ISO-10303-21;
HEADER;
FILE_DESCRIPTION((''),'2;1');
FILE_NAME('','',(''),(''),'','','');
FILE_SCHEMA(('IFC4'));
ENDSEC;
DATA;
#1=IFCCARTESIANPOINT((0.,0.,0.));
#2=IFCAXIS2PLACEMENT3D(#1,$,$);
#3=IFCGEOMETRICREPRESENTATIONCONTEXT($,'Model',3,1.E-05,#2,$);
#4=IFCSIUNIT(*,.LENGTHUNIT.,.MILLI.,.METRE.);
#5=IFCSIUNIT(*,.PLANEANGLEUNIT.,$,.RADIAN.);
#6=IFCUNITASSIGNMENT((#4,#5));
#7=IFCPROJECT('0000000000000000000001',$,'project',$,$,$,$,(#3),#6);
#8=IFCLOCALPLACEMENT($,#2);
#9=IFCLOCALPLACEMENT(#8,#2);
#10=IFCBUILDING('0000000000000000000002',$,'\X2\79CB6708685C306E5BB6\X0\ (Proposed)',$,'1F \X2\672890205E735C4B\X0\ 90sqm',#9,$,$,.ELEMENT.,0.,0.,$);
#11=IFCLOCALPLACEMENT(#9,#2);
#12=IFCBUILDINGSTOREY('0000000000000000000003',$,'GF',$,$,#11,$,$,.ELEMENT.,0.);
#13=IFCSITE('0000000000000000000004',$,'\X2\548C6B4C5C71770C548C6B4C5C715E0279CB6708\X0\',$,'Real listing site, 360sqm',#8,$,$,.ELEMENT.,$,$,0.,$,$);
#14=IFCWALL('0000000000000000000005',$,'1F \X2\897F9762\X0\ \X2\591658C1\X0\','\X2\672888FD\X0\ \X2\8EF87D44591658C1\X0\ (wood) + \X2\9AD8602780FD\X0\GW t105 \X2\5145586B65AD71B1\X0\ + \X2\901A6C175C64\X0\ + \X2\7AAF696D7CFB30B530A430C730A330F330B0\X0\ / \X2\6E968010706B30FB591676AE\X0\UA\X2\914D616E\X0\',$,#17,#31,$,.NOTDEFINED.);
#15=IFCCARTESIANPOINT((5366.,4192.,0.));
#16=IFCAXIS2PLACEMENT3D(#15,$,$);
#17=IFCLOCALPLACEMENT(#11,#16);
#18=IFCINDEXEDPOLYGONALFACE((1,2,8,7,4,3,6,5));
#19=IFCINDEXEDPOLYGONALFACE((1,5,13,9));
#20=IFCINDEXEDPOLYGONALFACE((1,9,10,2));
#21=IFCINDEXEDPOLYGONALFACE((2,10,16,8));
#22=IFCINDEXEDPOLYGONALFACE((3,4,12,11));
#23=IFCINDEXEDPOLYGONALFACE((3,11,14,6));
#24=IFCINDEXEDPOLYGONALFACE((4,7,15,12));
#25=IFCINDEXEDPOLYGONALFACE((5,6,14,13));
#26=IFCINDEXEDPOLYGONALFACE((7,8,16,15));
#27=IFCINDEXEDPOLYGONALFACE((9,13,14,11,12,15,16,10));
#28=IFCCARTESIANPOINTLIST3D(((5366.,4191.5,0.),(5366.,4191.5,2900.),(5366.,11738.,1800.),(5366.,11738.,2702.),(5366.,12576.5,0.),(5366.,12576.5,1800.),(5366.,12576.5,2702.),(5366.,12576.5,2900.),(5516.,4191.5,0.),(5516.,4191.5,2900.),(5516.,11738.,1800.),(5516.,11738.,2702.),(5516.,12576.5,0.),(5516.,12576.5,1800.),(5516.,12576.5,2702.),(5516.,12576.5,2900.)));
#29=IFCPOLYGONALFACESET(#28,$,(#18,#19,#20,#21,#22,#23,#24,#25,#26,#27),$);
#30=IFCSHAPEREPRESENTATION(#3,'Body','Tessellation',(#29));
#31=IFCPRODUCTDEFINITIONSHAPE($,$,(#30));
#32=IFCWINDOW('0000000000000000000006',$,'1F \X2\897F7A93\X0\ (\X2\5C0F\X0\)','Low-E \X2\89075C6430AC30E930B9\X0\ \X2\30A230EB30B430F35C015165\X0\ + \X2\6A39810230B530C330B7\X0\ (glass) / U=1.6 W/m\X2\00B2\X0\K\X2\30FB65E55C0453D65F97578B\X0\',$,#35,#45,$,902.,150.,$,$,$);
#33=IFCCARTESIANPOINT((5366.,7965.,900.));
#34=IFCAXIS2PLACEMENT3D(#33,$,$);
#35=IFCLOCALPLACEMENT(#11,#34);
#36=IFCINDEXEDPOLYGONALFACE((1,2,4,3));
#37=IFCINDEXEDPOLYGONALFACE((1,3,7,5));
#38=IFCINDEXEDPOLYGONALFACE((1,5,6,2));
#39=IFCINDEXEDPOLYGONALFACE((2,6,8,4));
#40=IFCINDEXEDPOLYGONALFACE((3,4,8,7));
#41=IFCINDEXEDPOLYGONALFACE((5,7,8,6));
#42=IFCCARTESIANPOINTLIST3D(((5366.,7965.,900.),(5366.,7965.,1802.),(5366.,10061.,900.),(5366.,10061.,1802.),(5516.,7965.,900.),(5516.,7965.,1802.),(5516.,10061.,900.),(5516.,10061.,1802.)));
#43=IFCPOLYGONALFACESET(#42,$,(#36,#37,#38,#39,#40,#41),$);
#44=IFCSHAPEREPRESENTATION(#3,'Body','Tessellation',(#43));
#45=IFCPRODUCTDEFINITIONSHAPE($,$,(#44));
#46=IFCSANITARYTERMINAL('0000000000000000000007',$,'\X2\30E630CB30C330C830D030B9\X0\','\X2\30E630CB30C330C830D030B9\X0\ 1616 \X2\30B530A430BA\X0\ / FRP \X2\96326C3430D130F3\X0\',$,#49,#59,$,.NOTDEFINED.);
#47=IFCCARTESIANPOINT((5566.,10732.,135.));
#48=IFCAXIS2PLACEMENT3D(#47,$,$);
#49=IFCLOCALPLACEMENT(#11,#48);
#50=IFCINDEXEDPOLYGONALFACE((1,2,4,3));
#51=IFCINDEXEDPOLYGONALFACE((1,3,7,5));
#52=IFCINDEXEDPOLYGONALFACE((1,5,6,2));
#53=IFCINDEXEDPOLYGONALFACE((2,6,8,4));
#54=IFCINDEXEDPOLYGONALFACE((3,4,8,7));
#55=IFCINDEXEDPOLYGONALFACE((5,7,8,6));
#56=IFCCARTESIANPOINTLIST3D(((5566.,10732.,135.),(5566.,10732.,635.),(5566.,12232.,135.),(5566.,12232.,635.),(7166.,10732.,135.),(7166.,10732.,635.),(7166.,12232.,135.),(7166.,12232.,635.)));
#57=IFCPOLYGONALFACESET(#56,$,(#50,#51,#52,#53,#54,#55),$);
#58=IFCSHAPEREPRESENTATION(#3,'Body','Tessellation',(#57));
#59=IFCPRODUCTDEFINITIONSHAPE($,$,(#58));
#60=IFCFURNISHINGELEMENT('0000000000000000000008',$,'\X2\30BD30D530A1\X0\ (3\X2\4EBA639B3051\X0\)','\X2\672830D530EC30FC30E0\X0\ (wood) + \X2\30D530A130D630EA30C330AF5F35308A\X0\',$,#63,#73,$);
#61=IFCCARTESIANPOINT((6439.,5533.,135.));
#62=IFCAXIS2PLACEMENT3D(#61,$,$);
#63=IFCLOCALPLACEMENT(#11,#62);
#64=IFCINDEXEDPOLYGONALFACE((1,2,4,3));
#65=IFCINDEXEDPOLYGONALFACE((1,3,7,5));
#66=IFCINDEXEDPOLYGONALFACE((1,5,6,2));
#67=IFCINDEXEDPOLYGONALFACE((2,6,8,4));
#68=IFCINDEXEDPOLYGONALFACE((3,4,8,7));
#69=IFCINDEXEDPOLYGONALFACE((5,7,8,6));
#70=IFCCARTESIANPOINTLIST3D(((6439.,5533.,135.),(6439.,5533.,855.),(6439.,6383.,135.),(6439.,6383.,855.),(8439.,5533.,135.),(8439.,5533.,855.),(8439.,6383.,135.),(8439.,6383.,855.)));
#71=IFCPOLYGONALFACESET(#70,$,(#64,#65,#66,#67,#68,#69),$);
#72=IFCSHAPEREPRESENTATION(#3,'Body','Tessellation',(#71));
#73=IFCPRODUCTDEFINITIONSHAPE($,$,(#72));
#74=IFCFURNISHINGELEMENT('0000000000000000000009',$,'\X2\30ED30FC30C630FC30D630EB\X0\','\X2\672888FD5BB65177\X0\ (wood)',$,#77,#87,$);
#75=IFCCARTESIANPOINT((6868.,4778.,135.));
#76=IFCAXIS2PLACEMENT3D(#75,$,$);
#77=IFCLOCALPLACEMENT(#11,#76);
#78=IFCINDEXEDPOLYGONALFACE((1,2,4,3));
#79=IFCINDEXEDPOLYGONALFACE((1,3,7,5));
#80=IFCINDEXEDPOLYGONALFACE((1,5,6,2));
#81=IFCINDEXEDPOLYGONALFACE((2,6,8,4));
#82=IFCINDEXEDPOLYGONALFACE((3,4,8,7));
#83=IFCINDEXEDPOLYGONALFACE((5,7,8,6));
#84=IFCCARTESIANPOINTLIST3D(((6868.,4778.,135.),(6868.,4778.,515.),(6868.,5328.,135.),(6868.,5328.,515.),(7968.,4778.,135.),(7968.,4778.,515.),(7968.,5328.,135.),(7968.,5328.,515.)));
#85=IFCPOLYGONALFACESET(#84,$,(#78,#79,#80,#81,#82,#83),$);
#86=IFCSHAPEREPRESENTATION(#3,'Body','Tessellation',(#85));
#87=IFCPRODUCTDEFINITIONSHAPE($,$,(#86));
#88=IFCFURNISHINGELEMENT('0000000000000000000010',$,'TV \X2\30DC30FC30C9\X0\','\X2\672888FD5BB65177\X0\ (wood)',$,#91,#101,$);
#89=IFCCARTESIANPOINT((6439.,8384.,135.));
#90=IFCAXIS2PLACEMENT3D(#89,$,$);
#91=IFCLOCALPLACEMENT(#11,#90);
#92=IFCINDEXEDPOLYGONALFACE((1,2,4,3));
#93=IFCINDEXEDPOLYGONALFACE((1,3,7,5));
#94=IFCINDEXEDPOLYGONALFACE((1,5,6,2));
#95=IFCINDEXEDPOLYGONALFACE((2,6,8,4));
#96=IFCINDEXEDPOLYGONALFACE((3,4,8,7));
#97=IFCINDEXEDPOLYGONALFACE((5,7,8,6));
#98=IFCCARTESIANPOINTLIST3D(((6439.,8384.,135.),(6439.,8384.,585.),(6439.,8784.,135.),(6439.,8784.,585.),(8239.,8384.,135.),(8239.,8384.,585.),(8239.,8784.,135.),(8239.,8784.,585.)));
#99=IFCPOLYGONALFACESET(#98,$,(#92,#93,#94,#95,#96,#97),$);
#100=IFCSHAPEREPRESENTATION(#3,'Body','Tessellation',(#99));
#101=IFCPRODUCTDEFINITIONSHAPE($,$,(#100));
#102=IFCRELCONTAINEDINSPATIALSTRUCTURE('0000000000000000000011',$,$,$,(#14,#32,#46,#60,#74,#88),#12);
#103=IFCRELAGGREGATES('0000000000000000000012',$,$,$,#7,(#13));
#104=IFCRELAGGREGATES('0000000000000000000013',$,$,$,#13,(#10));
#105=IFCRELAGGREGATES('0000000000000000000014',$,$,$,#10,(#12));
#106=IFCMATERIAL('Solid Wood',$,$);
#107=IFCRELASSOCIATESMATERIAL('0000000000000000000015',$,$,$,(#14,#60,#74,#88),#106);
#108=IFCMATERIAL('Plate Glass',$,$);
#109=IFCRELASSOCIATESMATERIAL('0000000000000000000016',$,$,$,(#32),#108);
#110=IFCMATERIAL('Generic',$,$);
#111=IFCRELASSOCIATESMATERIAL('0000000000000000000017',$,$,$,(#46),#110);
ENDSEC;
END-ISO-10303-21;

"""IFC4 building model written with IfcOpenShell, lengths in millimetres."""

from ifc_helpers import new_model, si_unit, frame, frame_2d, origin, place, context, project, spatial, rectangle, extrude, material, element, fill, save


model = new_model("IFC4")

# Units and contexts
model_context = context("Model", 3, precision=1e-05, world=origin())
ifc_project = project(units=[si_unit("LENGTHUNIT", "METRE", prefix="MILLI"), si_unit("PLANEANGLEUNIT", "RADIAN")], contexts=[model_context])

# Site, building, storey
site_placement = place(None, origin())
site = spatial("IfcSite", under=ifc_project, at=site_placement, Name="和歌山県和歌山市秋月", ObjectType="Real listing site, 360sqm", CompositionType="ELEMENT", RefElevation=0.0)
building_placement = place(site_placement, origin())
building = spatial("IfcBuilding", under=site, at=building_placement, Name="秋月桜の家 (Proposed)", ObjectType="1F 木造平屋 90sqm", CompositionType="ELEMENT", ElevationOfRefHeight=0.0, ElevationOfTerrain=0.0)
storey_placement = place(building_placement, origin())
storey = spatial("IfcBuildingStorey", under=building, at=storey_placement, Name="GF", CompositionType="ELEMENT", Elevation=0.0)

# Shared definitions
ifc_material_1 = material(Name="Solid Wood")

# Shared definitions
ifc_material_2 = material(Name="Plate Glass")

# Wall, opening, window
wall_1_placement = place(storey_placement, frame((5366.0, 4192.0, 0.0)))
wall_1 = element("IfcWall", 1, at=wall_1_placement, inside=storey, material=ifc_material_1, Name="1F 西面 外壁", Description="木製 軸組外壁 (wood) + 高性能GW t105 充填断熱 + 通気層 + 窯業系サイディング / 準耐火・外皮UA配慮", PredefinedType="NOTDEFINED", context=model_context, shape_type="SweptSolid", body=[
    extrude(rectangle(XDim=150.0, YDim=8385.0, at=frame_2d((75.0, 4192.0))), frame((5366.0, 4192.0, 0.0)), (0.0, 0.0, 1.0), 2900.0),
])
opening_1_placement = place(storey_placement, frame((5366.0, 7965.0, 900.0)))
opening_1 = element("IfcOpeningElement", 2, at=opening_1_placement, cuts=wall_1, PredefinedType="NOTDEFINED", context=model_context, shape_type="SweptSolid", body=[
    extrude(rectangle(XDim=150.0, YDim=2096.0, at=frame_2d((75.0, 1048.0))), frame((5366.0, 7965.0, 900.0)), (0.0, 0.0, 1.0), 902.0),
])
window_1_placement = place(storey_placement, frame((5366.0, 7965.0, 900.0)))
window_1 = element("IfcWindow", 3, at=window_1_placement, inside=storey, material=ifc_material_2, Name="1F 西窓 (小)", Description="Low-E 複層ガラス アルゴン封入 + 樹脂サッシ (glass) / U=1.6 W/m²K・日射取得型", OverallHeight=902.0, OverallWidth=150.0, context=model_context, shape_type="SweptSolid", body=[
    extrude(rectangle(XDim=150.0, YDim=2096.0, at=frame_2d((75.0, 1048.0))), frame((5366.0, 7965.0, 900.0)), (0.0, 0.0, 1.0), 902.0),
])
fill(opening_1, window_1)

# Shared definitions
ifc_material_3 = material(Name="Generic")

# Sanitary terminal
sanitary_terminal_placement = place(storey_placement, frame((5566.0, 10732.0, 135.0)))
element("IfcSanitaryTerminal", 4, at=sanitary_terminal_placement, inside=storey, material=ifc_material_3, Name="ユニットバス", Description="ユニットバス 1616 サイズ / FRP 防水パン", PredefinedType="NOTDEFINED", context=model_context, shape_type="SweptSolid", body=[
    extrude(rectangle(XDim=1600.0, YDim=1500.0, at=frame_2d((800.0, 750.0))), frame((5566.0, 10732.0, 135.0)), (0.0, 0.0, 1.0), 500.0),
])

# Furnishing elements
furnishing_1_placement = place(storey_placement, frame((6439.0, 5533.0, 135.0)))
element("IfcFurnishingElement", 5, at=furnishing_1_placement, inside=storey, material=ifc_material_1, Name="ソファ (3人掛け)", Description="木フレーム (wood) + ファブリック張り", context=model_context, shape_type="SweptSolid", body=[
    extrude(rectangle(XDim=2000.0, YDim=850.0, at=frame_2d((1000.0, 425.0))), frame((6439.0, 5533.0, 135.0)), (0.0, 0.0, 1.0), 720.0),
])
furnishing_2_placement = place(storey_placement, frame((6868.0, 4778.0, 135.0)))
element("IfcFurnishingElement", 6, at=furnishing_2_placement, inside=storey, material=ifc_material_1, Name="ローテーブル", Description="木製家具 (wood)", context=model_context, shape_type="SweptSolid", body=[
    extrude(rectangle(XDim=1100.0, YDim=550.0, at=frame_2d((550.0, 275.0))), frame((6868.0, 4778.0, 135.0)), (0.0, 0.0, 1.0), 380.0),
])
furnishing_3_placement = place(storey_placement, frame((6439.0, 8384.0, 135.0)))
element("IfcFurnishingElement", 7, at=furnishing_3_placement, inside=storey, material=ifc_material_1, Name="TV ボード", Description="木製家具 (wood)", context=model_context, shape_type="SweptSolid", body=[
    extrude(rectangle(XDim=1800.0, YDim=400.0, at=frame_2d((900.0, 200.0))), frame((6439.0, 8384.0, 135.0)), (0.0, 0.0, 1.0), 450.0),
])

save(model, "model.ifc")
